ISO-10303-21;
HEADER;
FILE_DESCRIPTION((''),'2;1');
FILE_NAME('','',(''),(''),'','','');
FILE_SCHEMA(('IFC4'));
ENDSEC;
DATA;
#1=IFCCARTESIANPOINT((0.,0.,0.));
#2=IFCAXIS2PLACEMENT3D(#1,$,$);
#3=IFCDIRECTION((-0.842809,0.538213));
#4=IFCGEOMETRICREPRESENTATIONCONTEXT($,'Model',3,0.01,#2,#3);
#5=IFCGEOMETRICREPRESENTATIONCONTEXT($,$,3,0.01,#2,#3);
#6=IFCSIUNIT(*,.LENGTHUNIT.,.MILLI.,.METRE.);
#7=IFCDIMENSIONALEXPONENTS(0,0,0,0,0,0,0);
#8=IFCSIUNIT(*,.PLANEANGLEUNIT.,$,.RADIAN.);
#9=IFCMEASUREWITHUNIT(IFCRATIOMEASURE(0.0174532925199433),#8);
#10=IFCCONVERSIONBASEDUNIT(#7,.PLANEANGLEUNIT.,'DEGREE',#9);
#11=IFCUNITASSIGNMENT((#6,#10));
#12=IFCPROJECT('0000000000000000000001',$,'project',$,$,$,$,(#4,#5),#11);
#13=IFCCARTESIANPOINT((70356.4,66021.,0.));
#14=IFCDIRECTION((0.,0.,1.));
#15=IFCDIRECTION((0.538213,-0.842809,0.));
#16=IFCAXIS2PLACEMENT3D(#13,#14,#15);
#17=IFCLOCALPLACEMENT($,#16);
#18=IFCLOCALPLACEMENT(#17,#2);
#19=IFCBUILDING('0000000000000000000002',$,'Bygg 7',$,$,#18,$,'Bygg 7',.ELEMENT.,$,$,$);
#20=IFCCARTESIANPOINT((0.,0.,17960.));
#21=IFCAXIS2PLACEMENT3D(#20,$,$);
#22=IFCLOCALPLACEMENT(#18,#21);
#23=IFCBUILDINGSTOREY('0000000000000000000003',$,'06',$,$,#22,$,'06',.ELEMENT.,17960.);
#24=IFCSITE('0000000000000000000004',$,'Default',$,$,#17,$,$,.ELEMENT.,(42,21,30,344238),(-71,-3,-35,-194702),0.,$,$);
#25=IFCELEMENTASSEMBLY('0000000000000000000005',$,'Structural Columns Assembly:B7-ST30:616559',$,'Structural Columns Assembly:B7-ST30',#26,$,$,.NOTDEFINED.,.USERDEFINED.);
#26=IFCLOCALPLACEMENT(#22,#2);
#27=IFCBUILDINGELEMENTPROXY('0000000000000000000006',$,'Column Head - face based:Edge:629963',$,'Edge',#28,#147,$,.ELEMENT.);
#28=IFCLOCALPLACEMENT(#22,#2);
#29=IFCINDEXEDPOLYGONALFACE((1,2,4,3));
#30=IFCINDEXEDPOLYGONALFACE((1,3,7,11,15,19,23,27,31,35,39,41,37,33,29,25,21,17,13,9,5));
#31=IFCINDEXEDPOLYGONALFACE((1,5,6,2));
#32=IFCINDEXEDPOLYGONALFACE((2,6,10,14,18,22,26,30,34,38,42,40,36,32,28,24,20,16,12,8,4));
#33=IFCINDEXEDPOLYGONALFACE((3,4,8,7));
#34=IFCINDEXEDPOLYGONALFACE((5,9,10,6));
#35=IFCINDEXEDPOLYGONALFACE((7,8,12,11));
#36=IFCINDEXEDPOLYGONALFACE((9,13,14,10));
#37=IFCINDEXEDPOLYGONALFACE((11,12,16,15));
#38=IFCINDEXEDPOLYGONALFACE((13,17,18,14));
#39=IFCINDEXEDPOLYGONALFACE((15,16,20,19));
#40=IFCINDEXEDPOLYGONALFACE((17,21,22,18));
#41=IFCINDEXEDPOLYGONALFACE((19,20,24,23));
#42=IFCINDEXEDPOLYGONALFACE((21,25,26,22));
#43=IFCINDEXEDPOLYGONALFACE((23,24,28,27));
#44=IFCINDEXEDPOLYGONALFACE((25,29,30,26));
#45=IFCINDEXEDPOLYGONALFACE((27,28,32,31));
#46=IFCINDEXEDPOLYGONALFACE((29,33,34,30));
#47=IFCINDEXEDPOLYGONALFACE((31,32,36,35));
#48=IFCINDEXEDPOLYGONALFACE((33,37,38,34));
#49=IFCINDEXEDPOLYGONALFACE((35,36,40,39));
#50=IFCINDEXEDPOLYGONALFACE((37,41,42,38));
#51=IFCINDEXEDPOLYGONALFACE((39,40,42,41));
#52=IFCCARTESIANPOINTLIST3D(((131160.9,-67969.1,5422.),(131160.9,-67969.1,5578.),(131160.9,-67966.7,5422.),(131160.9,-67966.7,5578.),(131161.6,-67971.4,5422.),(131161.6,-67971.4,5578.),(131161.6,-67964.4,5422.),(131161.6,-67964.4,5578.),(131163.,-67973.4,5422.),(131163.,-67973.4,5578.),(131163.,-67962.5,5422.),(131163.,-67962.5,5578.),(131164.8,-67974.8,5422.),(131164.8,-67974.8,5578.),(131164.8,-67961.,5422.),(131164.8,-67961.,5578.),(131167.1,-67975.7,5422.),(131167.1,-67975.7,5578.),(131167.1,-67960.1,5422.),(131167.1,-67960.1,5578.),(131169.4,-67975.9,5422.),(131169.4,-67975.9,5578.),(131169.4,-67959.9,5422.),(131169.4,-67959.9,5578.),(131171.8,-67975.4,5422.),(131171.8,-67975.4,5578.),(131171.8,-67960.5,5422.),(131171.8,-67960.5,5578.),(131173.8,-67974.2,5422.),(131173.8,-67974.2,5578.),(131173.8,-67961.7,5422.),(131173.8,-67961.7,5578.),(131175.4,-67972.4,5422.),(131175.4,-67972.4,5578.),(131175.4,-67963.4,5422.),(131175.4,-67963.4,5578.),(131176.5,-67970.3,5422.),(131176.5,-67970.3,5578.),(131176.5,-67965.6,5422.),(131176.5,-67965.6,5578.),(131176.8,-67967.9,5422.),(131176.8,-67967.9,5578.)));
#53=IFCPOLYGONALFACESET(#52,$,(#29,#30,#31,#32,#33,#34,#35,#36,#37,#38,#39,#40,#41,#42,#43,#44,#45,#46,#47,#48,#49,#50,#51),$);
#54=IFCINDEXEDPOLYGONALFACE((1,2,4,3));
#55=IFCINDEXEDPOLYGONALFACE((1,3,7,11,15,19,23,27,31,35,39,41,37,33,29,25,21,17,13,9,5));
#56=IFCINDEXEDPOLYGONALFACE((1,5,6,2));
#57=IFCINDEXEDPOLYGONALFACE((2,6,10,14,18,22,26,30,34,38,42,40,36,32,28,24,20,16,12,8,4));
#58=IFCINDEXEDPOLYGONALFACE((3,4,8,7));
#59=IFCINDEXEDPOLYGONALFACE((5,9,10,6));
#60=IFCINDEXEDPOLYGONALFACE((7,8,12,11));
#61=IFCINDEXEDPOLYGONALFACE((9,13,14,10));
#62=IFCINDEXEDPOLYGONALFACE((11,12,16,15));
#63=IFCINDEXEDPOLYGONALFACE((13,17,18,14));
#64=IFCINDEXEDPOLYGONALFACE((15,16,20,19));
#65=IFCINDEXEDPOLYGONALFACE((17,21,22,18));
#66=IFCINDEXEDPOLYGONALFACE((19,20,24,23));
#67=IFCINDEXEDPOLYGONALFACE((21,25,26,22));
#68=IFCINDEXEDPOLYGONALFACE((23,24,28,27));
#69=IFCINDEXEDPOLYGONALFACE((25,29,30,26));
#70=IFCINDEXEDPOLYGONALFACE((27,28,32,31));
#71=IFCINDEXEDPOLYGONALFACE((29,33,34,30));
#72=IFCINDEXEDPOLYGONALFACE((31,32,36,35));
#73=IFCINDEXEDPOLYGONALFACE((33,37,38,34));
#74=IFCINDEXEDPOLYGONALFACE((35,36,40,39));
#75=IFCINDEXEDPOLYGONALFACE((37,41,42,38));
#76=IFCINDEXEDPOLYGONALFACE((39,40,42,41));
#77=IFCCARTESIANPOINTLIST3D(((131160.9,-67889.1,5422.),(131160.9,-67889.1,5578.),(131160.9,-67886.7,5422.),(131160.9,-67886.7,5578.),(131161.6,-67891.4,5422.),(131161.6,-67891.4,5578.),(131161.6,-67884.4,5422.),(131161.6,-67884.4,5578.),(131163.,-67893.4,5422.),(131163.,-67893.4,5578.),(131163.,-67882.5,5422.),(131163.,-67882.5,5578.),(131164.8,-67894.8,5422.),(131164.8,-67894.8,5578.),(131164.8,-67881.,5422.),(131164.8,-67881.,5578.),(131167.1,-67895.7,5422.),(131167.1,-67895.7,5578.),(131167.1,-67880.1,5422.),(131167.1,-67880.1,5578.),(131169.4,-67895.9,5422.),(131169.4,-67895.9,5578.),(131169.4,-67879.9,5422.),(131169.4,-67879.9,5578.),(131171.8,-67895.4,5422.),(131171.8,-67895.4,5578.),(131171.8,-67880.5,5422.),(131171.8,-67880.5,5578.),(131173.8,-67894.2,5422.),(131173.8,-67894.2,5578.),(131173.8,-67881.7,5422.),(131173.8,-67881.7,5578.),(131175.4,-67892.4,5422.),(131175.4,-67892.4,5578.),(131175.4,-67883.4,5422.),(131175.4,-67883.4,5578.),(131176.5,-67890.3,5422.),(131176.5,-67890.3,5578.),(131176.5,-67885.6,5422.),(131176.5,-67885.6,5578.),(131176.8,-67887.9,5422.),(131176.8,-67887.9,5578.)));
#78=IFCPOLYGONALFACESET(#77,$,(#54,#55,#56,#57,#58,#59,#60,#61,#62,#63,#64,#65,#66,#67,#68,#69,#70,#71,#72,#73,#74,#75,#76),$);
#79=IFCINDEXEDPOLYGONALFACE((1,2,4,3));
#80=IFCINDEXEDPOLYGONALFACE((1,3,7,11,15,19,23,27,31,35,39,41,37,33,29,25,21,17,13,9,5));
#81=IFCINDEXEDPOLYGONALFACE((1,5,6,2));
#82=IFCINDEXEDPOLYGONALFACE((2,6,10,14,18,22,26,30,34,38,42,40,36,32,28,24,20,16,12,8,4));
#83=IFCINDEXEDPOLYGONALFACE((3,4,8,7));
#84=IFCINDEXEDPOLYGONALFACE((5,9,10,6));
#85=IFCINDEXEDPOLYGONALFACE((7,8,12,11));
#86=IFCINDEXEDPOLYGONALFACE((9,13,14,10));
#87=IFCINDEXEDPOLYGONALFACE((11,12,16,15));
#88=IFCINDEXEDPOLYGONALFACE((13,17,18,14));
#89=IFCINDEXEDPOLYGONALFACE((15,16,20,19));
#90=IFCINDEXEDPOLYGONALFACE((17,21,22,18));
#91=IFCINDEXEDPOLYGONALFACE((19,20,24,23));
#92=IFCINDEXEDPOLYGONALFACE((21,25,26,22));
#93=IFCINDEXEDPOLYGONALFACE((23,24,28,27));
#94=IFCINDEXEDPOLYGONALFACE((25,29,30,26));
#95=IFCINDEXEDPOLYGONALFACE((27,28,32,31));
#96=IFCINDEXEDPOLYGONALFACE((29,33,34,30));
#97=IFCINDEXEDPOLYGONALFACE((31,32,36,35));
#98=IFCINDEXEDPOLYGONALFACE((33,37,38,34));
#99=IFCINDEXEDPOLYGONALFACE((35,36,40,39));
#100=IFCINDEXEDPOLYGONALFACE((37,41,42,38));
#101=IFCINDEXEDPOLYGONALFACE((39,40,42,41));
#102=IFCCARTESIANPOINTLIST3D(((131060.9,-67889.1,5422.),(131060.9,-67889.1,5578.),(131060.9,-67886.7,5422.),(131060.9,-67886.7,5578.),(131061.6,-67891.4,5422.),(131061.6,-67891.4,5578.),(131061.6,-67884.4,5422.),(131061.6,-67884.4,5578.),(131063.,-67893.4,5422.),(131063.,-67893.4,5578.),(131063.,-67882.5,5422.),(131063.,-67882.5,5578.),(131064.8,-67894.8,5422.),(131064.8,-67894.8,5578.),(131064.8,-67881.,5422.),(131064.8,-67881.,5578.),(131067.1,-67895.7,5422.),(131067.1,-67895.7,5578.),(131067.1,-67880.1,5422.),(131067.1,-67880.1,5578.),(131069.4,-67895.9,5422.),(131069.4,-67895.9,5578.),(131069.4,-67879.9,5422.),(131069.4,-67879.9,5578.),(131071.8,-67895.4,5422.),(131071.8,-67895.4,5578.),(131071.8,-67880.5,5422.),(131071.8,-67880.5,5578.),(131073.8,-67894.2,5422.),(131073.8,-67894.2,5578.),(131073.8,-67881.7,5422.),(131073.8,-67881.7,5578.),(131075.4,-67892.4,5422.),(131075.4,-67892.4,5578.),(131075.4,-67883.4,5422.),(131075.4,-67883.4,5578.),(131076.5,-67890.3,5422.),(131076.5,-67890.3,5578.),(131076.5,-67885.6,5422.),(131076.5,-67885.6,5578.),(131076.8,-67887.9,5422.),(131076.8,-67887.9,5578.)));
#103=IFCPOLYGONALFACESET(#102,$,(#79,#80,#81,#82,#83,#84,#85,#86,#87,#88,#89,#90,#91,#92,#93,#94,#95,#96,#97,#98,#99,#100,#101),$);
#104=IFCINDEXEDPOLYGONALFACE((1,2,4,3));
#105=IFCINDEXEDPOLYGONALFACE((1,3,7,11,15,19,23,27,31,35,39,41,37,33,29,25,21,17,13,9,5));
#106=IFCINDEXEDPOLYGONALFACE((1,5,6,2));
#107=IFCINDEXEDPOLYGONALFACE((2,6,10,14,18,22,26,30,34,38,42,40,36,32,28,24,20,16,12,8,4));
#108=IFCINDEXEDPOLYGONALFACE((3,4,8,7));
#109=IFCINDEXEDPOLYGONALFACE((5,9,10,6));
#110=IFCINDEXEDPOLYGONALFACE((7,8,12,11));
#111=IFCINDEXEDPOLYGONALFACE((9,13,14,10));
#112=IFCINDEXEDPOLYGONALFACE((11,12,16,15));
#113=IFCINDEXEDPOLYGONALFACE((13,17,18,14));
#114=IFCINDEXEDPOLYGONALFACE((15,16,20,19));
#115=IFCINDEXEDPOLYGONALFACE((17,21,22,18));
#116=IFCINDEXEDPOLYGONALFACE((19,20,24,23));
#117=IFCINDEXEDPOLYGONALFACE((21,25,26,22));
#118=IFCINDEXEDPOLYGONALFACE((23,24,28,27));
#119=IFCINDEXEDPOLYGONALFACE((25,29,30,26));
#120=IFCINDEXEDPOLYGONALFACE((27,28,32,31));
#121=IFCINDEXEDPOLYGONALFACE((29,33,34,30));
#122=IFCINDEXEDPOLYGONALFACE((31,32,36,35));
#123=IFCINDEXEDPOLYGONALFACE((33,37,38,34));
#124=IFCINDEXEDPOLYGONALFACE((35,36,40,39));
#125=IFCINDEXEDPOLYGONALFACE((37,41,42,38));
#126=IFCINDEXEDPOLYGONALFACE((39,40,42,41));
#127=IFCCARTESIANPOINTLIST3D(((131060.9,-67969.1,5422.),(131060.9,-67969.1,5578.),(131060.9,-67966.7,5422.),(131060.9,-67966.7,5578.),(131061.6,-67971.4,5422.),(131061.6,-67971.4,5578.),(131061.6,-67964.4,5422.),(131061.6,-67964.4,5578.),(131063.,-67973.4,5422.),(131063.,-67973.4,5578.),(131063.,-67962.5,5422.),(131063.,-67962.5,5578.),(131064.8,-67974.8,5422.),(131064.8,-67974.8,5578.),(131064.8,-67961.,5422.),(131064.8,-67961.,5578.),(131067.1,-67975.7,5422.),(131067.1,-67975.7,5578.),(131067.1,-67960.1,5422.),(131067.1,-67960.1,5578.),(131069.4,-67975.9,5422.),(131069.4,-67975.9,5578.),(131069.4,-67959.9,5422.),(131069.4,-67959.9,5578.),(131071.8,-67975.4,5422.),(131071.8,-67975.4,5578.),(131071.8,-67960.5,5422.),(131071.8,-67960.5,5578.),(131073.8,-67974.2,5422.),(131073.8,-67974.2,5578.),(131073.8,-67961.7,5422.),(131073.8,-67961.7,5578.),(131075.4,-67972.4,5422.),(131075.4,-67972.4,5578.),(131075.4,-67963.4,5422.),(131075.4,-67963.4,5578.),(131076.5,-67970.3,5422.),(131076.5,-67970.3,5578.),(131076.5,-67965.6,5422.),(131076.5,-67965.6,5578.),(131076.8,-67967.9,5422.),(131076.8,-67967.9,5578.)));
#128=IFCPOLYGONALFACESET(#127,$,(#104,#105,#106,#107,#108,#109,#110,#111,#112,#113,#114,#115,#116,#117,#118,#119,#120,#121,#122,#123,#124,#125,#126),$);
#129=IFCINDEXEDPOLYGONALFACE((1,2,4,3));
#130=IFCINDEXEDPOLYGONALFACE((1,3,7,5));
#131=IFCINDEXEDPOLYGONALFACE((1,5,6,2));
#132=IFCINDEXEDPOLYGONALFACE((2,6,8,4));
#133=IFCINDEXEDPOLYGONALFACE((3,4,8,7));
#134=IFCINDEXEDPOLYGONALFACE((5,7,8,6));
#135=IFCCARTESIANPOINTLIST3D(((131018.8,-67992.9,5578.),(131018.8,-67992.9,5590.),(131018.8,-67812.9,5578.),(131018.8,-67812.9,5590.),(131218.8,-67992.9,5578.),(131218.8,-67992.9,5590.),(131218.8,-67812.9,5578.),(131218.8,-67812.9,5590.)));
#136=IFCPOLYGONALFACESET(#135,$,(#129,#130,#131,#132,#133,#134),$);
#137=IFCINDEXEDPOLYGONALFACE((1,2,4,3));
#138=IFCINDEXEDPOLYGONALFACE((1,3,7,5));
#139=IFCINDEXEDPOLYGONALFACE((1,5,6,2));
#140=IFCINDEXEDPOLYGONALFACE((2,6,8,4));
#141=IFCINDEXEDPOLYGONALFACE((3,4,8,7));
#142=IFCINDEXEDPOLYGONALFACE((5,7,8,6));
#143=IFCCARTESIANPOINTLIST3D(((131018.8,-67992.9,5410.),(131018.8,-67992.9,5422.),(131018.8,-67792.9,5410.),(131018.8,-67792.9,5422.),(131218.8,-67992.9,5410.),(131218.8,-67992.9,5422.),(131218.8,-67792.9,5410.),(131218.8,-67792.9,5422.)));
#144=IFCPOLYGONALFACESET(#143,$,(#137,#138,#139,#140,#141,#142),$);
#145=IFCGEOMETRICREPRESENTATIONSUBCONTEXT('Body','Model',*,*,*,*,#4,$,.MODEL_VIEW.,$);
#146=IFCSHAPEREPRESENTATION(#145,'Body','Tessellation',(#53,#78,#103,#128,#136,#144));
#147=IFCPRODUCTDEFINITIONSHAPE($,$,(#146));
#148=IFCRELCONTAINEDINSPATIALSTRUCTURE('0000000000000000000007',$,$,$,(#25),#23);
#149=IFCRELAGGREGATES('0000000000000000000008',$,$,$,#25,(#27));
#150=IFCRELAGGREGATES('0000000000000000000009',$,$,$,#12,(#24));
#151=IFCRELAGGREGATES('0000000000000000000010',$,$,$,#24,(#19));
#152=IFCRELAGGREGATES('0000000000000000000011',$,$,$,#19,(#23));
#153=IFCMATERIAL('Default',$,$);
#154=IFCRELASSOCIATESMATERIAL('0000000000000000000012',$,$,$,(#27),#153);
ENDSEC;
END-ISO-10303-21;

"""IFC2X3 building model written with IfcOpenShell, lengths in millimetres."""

from ifc_helpers import new_model, entity, si_unit, converted_unit, direction, frame, frame_2d, origin, origin_2d_with_axis, place, context, subcontext, project, spatial, rectangle, circle, extrude, source, transform, mapped, material, element, aggregate, save


model = new_model("IFC2X3")

# Units and contexts
model_context = context("Model", 3, precision=0.01, world=origin(), true_north=direction((-0.842809, 0.538213)))
context_of_model = context(None, 3, precision=0.01, world=origin(), true_north=direction((-0.842809, 0.538213)))
body_context = subcontext(model_context, "Body", "Model", "MODEL_VIEW")
ifc_project = project(units=[si_unit("LENGTHUNIT", "METRE", prefix="MILLI"), converted_unit("PLANEANGLEUNIT", "DEGREE", entity("IfcRatioMeasure", 0.0174532925199433), si_unit("PLANEANGLEUNIT", "RADIAN"), dimensions=[0, 0, 0, 0, 0, 0, 0])], contexts=[model_context, context_of_model])

# Site, building, storey
site_placement = place(None, frame((70356.4, 66021.0, 0.0), z_axis=(0.0, 0.0, 1.0), x_axis=(0.538213, -0.842809, 0.0)))
site = spatial("IfcSite", under=ifc_project, at=site_placement, Name="Default", CompositionType="ELEMENT", RefLatitude=(42, 21, 30, 344238), RefLongitude=(-71, -3, -35, -194702), RefElevation=0.0)
building_placement = place(site_placement, origin())
building = spatial("IfcBuilding", under=site, at=building_placement, Name="Bygg 7", LongName="Bygg 7", CompositionType="ELEMENT")
storey_placement = place(building_placement, frame((0.0, 0.0, 17960.0)))
storey = spatial("IfcBuildingStorey", under=building, at=storey_placement, Name="06", LongName="06", CompositionType="ELEMENT", Elevation=17960.0)

# Shared definitions
ifc_material_1 = material(Name="Default")

# Element assembly, building element proxy
assembly_1_placement = place(storey_placement, origin())
assembly_1 = element("IfcElementAssembly", 1, at=assembly_1_placement, inside=storey, Name="Structural Columns Assembly:B7-ST30:616559", ObjectType="Structural Columns Assembly:B7-ST30", AssemblyPlace="NOTDEFINED", PredefinedType="USERDEFINED")
shared_shape_1 = source(origin(), body_context, "Body", "SweptSolid", [
    extrude(circle(Radius=8.0, at=frame_2d((0.0, 0.0), x_axis=(1.0, 0.0))), frame((50.0, -135.0, 12.0)), (0.0, 0.0, 1.0), 156.0),
    extrude(circle(Radius=8.0, at=frame_2d((0.0, 0.0), x_axis=(1.0, 0.0))), frame((50.0, -55.0, 12.0)), (0.0, 0.0, 1.0), 156.0),
    extrude(circle(Radius=8.0, at=frame_2d((0.0, 0.0), x_axis=(1.0, 0.0))), frame((-50.0, -55.0, 12.0)), (0.0, 0.0, 1.0), 156.0),
    extrude(circle(Radius=8.0, at=frame_2d((0.0, 0.0), x_axis=(1.0, 0.0))), frame((-50.0, -135.0, 12.0)), (0.0, 0.0, 1.0), 156.0),
    extrude(rectangle(XDim=200.0, YDim=180.0, at=origin_2d_with_axis()), frame((0.0, -70.0, 168.0), z_axis=(0.0, 0.0, 1.0), x_axis=(-1.0, 0.0, 0.0)), (0.0, 0.0, 1.0), 12.0),
    extrude(rectangle(XDim=200.0, YDim=200.0, at=origin_2d_with_axis()), frame((0.0, -60.0, 0.0), z_axis=(0.0, 0.0, 1.0), x_axis=(0.0, 1.0, 0.0)), (0.0, 0.0, 1.0), 12.0),
])
proxy_1_placement = place(assembly_1_placement, frame((131118.8, -67832.9, 5410.0)))
proxy_1 = element("IfcBuildingElementProxy", 2, at=proxy_1_placement, material=ifc_material_1, Name="Column Head - face based:Edge:629963", ObjectType="Edge", CompositionType="ELEMENT", context=body_context, shape_type="MappedRepresentation", body=[
    mapped(shared_shape_1, transform((0.0, 0.0, 0.0), scale=1.0)),
])
aggregate(assembly_1, [proxy_1])

save(model, "model.ifc")
